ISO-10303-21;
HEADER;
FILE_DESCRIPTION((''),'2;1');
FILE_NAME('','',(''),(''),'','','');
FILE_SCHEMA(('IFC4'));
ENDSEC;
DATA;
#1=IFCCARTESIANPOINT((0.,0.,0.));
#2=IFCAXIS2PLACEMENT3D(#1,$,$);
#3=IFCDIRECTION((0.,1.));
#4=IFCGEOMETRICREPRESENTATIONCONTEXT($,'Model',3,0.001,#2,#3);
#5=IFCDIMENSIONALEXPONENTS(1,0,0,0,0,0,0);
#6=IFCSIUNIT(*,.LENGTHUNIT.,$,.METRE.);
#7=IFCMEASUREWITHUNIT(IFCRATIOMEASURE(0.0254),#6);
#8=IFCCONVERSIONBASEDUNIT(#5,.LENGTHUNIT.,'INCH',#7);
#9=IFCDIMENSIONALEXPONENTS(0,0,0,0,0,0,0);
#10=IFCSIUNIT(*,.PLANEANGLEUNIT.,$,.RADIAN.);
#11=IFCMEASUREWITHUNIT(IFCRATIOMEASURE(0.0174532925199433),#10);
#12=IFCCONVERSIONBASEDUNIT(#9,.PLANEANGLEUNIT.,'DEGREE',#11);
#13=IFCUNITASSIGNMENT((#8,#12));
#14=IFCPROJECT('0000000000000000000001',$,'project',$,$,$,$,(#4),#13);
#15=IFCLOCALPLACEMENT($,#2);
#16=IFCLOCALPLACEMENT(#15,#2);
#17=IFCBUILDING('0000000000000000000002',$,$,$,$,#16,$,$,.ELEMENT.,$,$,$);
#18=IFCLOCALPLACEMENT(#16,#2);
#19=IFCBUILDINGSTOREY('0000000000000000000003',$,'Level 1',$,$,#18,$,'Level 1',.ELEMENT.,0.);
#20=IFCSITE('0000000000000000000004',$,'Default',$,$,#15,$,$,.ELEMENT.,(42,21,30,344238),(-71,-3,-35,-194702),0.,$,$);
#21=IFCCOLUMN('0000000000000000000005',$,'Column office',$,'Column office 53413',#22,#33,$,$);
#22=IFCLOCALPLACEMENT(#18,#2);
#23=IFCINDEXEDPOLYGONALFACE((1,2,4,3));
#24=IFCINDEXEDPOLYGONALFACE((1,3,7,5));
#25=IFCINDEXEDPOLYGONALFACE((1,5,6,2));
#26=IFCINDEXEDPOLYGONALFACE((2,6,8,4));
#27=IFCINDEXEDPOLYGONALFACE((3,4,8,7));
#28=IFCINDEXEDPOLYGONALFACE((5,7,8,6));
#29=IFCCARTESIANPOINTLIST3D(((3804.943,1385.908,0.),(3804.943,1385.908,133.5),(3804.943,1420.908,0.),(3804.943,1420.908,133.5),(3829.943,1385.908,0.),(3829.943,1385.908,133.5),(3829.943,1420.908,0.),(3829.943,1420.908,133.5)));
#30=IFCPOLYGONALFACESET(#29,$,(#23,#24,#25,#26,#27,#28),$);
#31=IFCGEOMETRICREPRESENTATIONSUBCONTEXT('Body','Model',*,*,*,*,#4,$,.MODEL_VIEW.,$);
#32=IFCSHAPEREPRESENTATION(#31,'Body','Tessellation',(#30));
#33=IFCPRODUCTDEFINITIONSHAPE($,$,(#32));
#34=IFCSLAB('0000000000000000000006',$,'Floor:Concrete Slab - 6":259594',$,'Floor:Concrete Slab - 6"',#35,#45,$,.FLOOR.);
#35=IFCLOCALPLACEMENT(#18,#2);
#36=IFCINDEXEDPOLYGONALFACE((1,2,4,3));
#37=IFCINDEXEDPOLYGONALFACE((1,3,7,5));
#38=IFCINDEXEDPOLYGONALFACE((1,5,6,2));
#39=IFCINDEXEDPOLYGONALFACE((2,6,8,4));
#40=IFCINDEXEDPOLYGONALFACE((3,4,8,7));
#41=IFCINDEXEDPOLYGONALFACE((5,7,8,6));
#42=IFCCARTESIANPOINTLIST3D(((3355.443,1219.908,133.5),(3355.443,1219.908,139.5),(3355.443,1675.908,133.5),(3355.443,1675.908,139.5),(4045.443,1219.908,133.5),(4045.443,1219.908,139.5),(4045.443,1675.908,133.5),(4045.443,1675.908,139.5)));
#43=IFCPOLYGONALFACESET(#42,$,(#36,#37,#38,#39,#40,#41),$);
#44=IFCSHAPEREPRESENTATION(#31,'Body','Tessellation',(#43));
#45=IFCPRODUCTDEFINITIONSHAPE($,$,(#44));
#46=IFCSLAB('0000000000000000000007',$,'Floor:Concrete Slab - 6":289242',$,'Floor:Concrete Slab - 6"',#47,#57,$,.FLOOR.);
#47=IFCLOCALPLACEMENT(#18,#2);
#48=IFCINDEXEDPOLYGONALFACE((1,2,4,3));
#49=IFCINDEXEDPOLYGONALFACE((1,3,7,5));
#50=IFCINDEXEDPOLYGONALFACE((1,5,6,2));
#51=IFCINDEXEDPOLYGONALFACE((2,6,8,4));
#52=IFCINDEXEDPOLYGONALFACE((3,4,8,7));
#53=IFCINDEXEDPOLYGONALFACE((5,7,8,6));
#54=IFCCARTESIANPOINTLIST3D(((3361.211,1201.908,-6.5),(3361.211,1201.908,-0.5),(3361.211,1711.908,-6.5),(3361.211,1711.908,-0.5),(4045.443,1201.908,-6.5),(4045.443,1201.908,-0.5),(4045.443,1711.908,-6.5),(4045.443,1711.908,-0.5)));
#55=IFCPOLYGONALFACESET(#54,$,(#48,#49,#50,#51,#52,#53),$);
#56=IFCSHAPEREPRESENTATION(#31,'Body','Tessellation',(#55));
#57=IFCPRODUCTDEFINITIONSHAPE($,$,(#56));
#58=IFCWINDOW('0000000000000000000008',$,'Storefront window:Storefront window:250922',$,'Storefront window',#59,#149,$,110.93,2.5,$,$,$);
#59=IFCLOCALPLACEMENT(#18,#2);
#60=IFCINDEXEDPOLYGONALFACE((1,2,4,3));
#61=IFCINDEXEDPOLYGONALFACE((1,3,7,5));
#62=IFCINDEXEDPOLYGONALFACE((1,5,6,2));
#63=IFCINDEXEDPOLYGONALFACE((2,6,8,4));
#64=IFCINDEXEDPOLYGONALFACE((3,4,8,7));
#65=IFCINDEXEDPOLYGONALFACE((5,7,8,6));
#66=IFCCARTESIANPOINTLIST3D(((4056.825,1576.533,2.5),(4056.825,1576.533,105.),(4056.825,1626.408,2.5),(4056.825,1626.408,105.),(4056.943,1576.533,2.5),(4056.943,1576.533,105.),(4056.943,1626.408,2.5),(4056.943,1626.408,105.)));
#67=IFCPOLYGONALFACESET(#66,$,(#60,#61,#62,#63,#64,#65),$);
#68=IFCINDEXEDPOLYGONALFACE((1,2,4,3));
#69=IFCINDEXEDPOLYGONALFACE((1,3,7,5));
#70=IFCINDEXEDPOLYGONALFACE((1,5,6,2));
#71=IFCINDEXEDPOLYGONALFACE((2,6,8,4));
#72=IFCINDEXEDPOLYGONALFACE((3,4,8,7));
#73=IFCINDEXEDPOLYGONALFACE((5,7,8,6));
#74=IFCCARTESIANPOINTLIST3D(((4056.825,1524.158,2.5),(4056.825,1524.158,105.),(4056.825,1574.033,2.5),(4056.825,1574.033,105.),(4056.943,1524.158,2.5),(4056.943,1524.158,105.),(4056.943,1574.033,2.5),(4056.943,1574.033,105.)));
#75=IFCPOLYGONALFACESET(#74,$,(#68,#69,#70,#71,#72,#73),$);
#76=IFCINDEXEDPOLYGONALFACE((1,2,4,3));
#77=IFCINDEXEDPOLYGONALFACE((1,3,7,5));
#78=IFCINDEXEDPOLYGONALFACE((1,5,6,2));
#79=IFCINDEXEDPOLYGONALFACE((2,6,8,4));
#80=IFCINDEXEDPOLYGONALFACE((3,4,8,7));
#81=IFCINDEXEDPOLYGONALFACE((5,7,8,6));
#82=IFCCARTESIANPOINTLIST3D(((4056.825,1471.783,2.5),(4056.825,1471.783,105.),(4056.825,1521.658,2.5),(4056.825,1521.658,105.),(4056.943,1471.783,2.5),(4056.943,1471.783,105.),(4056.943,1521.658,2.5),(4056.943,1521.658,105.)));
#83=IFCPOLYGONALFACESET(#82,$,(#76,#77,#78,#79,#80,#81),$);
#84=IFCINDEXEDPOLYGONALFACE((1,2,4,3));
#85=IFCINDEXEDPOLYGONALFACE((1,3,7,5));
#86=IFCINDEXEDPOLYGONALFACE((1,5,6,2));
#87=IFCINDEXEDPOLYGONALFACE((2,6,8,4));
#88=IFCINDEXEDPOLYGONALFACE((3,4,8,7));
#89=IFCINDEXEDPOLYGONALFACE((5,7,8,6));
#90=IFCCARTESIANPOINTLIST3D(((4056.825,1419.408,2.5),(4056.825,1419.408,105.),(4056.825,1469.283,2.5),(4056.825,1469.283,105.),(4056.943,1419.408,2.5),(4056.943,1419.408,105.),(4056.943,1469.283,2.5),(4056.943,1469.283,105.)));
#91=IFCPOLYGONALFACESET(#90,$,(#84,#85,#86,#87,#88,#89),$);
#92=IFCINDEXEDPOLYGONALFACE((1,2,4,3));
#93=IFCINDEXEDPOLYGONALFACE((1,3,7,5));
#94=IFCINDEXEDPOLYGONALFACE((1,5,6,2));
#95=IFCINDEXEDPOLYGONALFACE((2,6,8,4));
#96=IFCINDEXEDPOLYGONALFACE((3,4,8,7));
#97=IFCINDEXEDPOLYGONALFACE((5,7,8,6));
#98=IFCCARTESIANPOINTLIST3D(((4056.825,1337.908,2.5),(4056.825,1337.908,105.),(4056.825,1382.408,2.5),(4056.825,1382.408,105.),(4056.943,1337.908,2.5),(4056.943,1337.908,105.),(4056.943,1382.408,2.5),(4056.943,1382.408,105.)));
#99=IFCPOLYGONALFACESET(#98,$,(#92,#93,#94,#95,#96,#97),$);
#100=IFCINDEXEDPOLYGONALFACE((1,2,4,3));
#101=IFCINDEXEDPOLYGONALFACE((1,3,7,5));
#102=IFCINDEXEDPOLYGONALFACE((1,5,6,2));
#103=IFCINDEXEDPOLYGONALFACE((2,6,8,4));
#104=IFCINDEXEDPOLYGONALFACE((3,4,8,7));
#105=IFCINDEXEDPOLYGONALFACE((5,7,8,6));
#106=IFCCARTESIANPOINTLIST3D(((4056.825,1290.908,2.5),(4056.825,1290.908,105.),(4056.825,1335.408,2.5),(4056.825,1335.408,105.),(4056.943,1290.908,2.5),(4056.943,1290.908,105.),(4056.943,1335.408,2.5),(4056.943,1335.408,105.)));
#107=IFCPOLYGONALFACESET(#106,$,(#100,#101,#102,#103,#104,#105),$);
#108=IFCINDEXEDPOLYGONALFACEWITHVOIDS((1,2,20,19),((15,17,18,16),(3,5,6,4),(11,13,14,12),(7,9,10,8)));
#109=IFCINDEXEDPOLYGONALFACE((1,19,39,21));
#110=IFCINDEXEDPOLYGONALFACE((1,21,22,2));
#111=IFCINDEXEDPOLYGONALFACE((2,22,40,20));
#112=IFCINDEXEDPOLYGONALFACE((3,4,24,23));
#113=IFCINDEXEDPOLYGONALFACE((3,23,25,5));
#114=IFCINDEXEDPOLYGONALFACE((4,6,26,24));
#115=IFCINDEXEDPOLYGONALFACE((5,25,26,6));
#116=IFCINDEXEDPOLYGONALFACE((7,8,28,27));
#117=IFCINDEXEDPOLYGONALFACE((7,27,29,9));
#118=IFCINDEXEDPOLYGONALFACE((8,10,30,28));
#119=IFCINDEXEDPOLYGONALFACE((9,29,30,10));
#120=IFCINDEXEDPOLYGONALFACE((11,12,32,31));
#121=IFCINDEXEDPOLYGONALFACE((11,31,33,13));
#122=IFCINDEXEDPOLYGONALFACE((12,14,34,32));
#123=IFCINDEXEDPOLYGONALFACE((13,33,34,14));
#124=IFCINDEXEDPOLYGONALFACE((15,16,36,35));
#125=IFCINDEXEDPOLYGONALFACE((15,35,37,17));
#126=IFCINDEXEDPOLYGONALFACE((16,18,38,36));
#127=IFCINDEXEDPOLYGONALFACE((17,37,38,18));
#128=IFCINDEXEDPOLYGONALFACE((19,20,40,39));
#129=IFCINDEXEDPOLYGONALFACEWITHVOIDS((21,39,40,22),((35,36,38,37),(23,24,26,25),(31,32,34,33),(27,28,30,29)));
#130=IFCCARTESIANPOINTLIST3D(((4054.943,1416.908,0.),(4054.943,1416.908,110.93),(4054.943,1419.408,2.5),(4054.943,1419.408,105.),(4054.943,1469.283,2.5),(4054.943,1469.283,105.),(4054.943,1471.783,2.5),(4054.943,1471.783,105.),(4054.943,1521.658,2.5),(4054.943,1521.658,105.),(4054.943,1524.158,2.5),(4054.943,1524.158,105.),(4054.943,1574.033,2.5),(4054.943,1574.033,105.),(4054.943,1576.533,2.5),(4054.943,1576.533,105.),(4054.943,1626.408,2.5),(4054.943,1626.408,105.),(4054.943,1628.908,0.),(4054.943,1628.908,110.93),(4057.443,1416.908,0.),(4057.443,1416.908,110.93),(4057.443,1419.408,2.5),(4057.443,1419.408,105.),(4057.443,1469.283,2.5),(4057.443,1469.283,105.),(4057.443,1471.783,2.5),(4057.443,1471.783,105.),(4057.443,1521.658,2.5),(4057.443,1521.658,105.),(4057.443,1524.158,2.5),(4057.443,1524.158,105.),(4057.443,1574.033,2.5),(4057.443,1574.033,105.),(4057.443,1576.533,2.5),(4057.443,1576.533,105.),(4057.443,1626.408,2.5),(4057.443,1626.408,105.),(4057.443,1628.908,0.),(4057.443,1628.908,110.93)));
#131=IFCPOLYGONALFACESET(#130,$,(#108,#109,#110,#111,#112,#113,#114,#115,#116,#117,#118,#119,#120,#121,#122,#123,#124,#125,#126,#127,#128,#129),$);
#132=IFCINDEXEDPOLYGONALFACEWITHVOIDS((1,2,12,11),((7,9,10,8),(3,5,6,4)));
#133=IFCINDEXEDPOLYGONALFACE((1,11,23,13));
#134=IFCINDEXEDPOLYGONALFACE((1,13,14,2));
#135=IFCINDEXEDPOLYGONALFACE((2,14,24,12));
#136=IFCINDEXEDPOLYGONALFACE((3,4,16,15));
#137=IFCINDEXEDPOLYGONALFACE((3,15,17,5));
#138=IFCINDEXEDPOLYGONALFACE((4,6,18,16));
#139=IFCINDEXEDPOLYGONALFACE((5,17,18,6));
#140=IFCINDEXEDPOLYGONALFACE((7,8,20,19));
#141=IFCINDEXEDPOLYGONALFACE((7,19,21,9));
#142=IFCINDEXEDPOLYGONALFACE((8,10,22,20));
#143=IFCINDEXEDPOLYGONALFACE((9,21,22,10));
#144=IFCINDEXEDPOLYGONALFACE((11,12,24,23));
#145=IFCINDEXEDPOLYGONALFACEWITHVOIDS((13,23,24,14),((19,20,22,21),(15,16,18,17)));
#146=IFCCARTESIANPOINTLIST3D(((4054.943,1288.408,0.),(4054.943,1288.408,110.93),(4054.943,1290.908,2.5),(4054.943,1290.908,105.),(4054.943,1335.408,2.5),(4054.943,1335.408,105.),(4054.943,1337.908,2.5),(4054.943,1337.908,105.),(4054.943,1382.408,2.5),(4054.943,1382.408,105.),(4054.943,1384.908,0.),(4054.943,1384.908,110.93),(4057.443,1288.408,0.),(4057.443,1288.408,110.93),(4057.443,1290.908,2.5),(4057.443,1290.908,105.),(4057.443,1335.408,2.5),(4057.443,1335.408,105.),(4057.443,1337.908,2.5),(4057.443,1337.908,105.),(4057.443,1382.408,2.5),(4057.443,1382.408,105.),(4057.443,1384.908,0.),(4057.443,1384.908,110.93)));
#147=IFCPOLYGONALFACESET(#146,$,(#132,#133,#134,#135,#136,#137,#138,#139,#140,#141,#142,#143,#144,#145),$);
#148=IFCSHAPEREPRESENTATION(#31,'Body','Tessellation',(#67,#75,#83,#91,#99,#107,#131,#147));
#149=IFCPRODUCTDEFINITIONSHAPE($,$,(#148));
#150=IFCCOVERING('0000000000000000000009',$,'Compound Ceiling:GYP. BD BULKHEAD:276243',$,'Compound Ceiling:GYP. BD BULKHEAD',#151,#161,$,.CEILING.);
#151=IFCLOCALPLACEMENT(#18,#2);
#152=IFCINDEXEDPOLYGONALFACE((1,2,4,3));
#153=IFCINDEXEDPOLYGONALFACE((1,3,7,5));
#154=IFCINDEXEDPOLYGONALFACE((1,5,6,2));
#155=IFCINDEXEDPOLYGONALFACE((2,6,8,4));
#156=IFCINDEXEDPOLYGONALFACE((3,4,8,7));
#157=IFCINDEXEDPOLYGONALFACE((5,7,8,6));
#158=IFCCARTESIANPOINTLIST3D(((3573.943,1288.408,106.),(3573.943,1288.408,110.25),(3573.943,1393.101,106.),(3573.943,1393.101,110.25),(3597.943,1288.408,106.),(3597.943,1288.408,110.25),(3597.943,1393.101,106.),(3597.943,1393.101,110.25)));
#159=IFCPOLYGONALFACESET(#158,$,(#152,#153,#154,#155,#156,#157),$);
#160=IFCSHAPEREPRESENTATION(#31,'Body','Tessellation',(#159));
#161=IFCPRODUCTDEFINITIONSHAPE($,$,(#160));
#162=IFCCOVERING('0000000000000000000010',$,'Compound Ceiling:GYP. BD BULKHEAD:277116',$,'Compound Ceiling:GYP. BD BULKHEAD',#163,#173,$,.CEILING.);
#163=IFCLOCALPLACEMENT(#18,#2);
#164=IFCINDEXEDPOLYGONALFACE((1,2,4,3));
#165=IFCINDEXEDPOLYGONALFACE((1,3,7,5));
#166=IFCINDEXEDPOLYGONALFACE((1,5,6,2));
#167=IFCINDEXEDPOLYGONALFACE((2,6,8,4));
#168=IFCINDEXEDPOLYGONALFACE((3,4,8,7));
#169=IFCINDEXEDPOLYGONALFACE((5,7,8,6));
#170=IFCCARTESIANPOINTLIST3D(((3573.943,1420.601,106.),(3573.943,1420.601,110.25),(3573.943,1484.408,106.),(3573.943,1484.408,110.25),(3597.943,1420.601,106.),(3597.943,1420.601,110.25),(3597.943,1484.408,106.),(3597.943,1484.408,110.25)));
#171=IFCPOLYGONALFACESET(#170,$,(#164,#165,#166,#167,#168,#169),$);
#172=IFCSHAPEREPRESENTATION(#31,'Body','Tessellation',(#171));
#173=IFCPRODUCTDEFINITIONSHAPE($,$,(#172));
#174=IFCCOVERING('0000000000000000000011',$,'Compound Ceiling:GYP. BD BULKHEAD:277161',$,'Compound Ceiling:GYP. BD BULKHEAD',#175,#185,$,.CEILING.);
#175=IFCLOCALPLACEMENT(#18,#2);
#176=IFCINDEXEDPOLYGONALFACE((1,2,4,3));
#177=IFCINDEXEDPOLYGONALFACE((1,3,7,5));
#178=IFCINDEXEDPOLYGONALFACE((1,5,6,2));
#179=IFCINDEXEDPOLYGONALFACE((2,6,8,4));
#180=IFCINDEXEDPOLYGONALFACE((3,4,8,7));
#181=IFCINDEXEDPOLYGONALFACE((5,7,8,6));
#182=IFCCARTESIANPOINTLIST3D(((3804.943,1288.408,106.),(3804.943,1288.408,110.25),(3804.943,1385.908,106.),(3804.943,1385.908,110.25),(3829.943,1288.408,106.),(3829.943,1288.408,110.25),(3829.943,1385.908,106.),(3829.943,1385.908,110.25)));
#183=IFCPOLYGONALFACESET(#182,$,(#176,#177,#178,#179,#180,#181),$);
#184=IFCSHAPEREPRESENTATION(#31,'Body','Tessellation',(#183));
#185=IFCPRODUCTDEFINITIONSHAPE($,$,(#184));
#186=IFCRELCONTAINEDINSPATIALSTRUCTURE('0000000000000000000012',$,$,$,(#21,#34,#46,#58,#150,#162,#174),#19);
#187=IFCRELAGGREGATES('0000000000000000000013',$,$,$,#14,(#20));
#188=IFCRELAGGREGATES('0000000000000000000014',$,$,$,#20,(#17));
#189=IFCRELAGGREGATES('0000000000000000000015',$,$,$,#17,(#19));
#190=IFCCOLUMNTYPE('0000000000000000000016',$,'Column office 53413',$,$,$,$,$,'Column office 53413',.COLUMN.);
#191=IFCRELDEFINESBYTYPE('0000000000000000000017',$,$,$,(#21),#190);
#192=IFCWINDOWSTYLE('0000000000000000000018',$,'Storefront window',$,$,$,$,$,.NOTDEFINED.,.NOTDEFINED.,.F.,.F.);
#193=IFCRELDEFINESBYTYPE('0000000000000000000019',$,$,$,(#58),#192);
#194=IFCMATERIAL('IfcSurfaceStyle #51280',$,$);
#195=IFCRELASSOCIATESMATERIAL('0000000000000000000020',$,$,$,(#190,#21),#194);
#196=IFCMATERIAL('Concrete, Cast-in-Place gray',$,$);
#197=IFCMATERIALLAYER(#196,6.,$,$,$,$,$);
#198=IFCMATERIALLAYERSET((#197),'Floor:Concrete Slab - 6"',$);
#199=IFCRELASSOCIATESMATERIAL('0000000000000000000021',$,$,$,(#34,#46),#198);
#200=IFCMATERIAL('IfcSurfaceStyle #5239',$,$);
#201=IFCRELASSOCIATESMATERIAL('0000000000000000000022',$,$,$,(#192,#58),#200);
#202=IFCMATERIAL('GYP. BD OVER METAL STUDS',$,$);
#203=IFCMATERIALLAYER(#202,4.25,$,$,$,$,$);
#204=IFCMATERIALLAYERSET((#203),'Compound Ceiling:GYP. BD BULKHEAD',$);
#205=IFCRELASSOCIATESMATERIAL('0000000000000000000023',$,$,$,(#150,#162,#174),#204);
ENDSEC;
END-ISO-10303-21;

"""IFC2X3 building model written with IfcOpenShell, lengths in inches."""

from ifc_helpers import new_model, entity, si_unit, converted_unit, direction, frame, frame_2d, origin, origin_2d_with_axis, place, context, subcontext, project, spatial, polyline, rectangle, outline, extrude, source, transform, mapped, material, layer, layer_set, layer_usage, type_object, type_shapes, element, save


model = new_model("IFC2X3")

# Units and contexts
model_context = context("Model", 3, precision=0.001, world=origin(), true_north=direction((0.0, 1.0)))
body_context = subcontext(model_context, "Body", "Model", "MODEL_VIEW")
ifc_project = project(units=[converted_unit("LENGTHUNIT", "INCH", entity("IfcRatioMeasure", 0.0254), si_unit("LENGTHUNIT", "METRE"), dimensions=[1, 0, 0, 0, 0, 0, 0]), converted_unit("PLANEANGLEUNIT", "DEGREE", entity("IfcRatioMeasure", 0.0174532925199433), si_unit("PLANEANGLEUNIT", "RADIAN"), dimensions=[0, 0, 0, 0, 0, 0, 0])], contexts=[model_context])

# Site, building, storey
site_placement = place(None, origin())
site = spatial("IfcSite", under=ifc_project, at=site_placement, Name="Default", CompositionType="ELEMENT", RefLatitude=(42, 21, 30, 344238), RefLongitude=(-71, -3, -35, -194702), RefElevation=0.0)
building_placement = place(site_placement, origin())
building = spatial("IfcBuilding", under=site, at=building_placement, CompositionType="ELEMENT")
storey_placement = place(building_placement, origin())
storey = spatial("IfcBuildingStorey", under=building, at=storey_placement, Name="Level 1", LongName="Level 1", CompositionType="ELEMENT", Elevation=0.0)

# Column
ifc_material_1 = material(Name="IfcSurfaceStyle #51280")
column_type = type_object("IfcColumnType", Name="Column office 53413", ElementType="Column office 53413", PredefinedType="COLUMN", material=ifc_material_1)
shared_shape_1 = source(origin(), body_context, "Body", "SweptSolid", [
    extrude(rectangle(XDim=35.0, YDim=25.0, at=frame_2d((0.0, 0.0), x_axis=(1.0, 0.0))), frame((3817.443, 1403.408, 0.0), z_axis=(0.0, 0.0, 1.0), x_axis=(0.0, -1.0, 0.0)), (0.0, 0.0, 1.0), 133.5),
])
type_shapes(column_type, [shared_shape_1])
column_placement = place(building_placement, origin())
element("IfcColumn", 1, at=column_placement, inside=storey, type_object=column_type, material=ifc_material_1, Name="Column office", ObjectType="Column office 53413", context=body_context, shape_type="MappedRepresentation", body=[
    mapped(shared_shape_1, transform((0.0, 0.0, 0.0), scale=1.0)),
])

# Slabs
ifc_material_2 = material(Name="Concrete, Cast-in-Place gray")
ifc_layer_1 = layer(ifc_material_2, 6.0)
ifc_layer_set_1 = layer_set([ifc_layer_1], Name="Floor:Concrete Slab - 6\"")
ifc_layer_usage_1 = layer_usage(ifc_layer_set_1, "AXIS3", "POSITIVE", 0.0)
slab_1_placement = place(building_placement, origin())
element("IfcSlab", 2, at=slab_1_placement, inside=storey, material=ifc_layer_usage_1, Name="Floor:Concrete Slab - 6\":259594", ObjectType="Floor:Concrete Slab - 6\"", PredefinedType="FLOOR", context=body_context, shape_type="SweptSolid", body=[
    extrude(rectangle(XDim=456.0, YDim=690.0, at=frame_2d((0.0, 0.0), x_axis=(1.0, 0.0))), frame((3700.443, 1447.908, 139.5), z_axis=(0.0, 0.0, -1.0), x_axis=(0.0, 1.0, 0.0)), (0.0, 0.0, 1.0), 6.0),
])
ifc_layer_usage_2 = layer_usage(ifc_layer_set_1, "AXIS3", "POSITIVE", 0.0)
slab_2_placement = place(building_placement, origin())
element("IfcSlab", 3, at=slab_2_placement, inside=storey, material=ifc_layer_usage_2, Name="Floor:Concrete Slab - 6\":289242", ObjectType="Floor:Concrete Slab - 6\"", PredefinedType="FLOOR", context=body_context, shape_type="SweptSolid", body=[
    extrude(rectangle(XDim=510.0, YDim=684.232, at=origin_2d_with_axis()), frame((3703.327, 1456.908, -0.5), z_axis=(0.0, 0.0, -1.0), x_axis=(0.0, 1.0, 0.0)), (0.0, 0.0, 1.0), 6.0),
])

# Window
ifc_material_3 = material(Name="IfcSurfaceStyle #5239")
window_style = type_object("IfcWindowStyle", Name="Storefront window", ConstructionType="NOTDEFINED", OperationType="NOTDEFINED", ParameterTakesPrecedence=False, Sizeable=False, material=ifc_material_3)
shared_shape_2 = source(origin(), body_context, "Body", "SweptSolid", [
    extrude(rectangle(XDim=0.118, YDim=49.875, at=frame_2d((0.0, 0.0), x_axis=(1.0, 0.0))), frame((4056.884, 1601.47, 2.5), z_axis=(0.0, 0.0, 1.0), x_axis=(-1.0, 0.0, 0.0)), (0.0, 0.0, 1.0), 102.5),
    extrude(rectangle(XDim=0.118, YDim=49.875, at=frame_2d((0.0, 0.0), x_axis=(1.0, 0.0))), frame((4056.884, 1549.095, 2.5), z_axis=(0.0, 0.0, 1.0), x_axis=(-1.0, 0.0, 0.0)), (0.0, 0.0, 1.0), 102.5),
    extrude(rectangle(XDim=0.118, YDim=49.875, at=frame_2d((0.0, 0.0), x_axis=(1.0, 0.0))), frame((4056.884, 1496.72, 2.5), z_axis=(0.0, 0.0, 1.0), x_axis=(-1.0, 0.0, 0.0)), (0.0, 0.0, 1.0), 102.5),
    extrude(rectangle(XDim=0.118, YDim=49.875, at=frame_2d((0.0, 0.0), x_axis=(1.0, 0.0))), frame((4056.884, 1444.345, 2.5), z_axis=(0.0, 0.0, 1.0), x_axis=(-1.0, 0.0, 0.0)), (0.0, 0.0, 1.0), 102.5),
    extrude(rectangle(XDim=0.118, YDim=44.5, at=frame_2d((0.0, 0.0), x_axis=(1.0, 0.0))), frame((4056.884, 1360.158, 2.5), z_axis=(0.0, 0.0, 1.0), x_axis=(-1.0, 0.0, 0.0)), (0.0, 0.0, 1.0), 102.5),
    extrude(rectangle(XDim=0.118, YDim=44.5, at=frame_2d((0.0, 0.0), x_axis=(1.0, 0.0))), frame((4056.884, 1313.158, 2.5), z_axis=(0.0, 0.0, 1.0), x_axis=(-1.0, 0.0, 0.0)), (0.0, 0.0, 1.0), 102.5),
    extrude(outline(polyline([(-55.465, -106.0), (55.465, -106.0), (55.465, 106.0), (-55.465, 106.0), (-55.465, -106.0)]), holes=[polyline([(-49.535, 53.625), (-49.535, 103.5), (52.965, 103.5), (52.965, 53.625), (-49.535, 53.625)]), polyline([(52.965, 1.25), (-49.535, 1.25), (-49.535, 51.125), (52.965, 51.125), (52.965, 1.25)]), polyline([(-49.535, -1.25), (52.965, -1.25), (52.965, -51.125), (-49.535, -51.125), (-49.535, -1.25)]), polyline([(-49.535, -103.5), (-49.535, -53.625), (52.965, -53.625), (52.965, -103.5), (-49.535, -103.5)])]), frame((4054.943, 1522.908, 55.465), z_axis=(1.0, 0.0, 0.0), x_axis=(0.0, 0.0, -1.0)), (0.0, 0.0, 1.0), 2.5),
    extrude(outline(polyline([(-55.465, -48.25), (55.465, -48.25), (55.465, 48.25), (-55.465, 48.25), (-55.465, -48.25)]), holes=[polyline([(-49.535, 1.25), (-49.535, 45.75), (52.965, 45.75), (52.965, 1.25), (-49.535, 1.25)]), polyline([(-49.535, -45.75), (-49.535, -1.25), (52.965, -1.25), (52.965, -45.75), (-49.535, -45.75)])]), frame((4054.943, 1336.658, 55.465), z_axis=(1.0, 0.0, 0.0), x_axis=(0.0, 0.0, -1.0)), (0.0, 0.0, 1.0), 2.5),
])
type_shapes(window_style, [shared_shape_2])
window_placement = place(building_placement, origin())
element("IfcWindow", 4, at=window_placement, inside=storey, type_object=window_style, material=ifc_material_3, Name="Storefront window:Storefront window:250922", ObjectType="Storefront window", OverallHeight=110.93, OverallWidth=2.5, context=body_context, shape_type="MappedRepresentation", body=[
    mapped(shared_shape_2, transform((0.0, 0.0, 0.0), scale=1.0)),
])

# Coverings
ifc_material_4 = material(Name="GYP. BD OVER METAL STUDS")
ifc_layer_2 = layer(ifc_material_4, 4.25)
ifc_layer_set_2 = layer_set([ifc_layer_2], Name="Compound Ceiling:GYP. BD BULKHEAD")
ifc_layer_usage_3 = layer_usage(ifc_layer_set_2, "AXIS3", "NEGATIVE", 0.0)
covering_1_placement = place(building_placement, origin())
element("IfcCovering", 5, at=covering_1_placement, inside=storey, material=ifc_layer_usage_3, Name="Compound Ceiling:GYP. BD BULKHEAD:276243", ObjectType="Compound Ceiling:GYP. BD BULKHEAD", PredefinedType="CEILING", context=body_context, shape_type="SweptSolid", body=[
    extrude(rectangle(XDim=24.0, YDim=104.693, at=frame_2d((0.0, 0.0), x_axis=(1.0, 0.0))), frame((3585.943, 1340.754, 106.0), z_axis=(0.0, 0.0, 1.0), x_axis=(-1.0, 0.0, 0.0)), (0.0, 0.0, 1.0), 4.25),
])
ifc_layer_usage_4 = layer_usage(ifc_layer_set_2, "AXIS3", "NEGATIVE", 0.0)
covering_2_placement = place(storey_placement, origin())
element("IfcCovering", 6, at=covering_2_placement, inside=storey, material=ifc_layer_usage_4, Name="Compound Ceiling:GYP. BD BULKHEAD:277116", ObjectType="Compound Ceiling:GYP. BD BULKHEAD", PredefinedType="CEILING", context=body_context, shape_type="SweptSolid", body=[
    extrude(rectangle(XDim=24.0, YDim=63.807, at=frame_2d((0.0, 0.0), x_axis=(1.0, 0.0))), frame((3585.943, 1452.504, 106.0), z_axis=(0.0, 0.0, 1.0), x_axis=(-1.0, 0.0, 0.0)), (0.0, 0.0, 1.0), 4.25),
])
ifc_layer_usage_5 = layer_usage(ifc_layer_set_2, "AXIS3", "NEGATIVE", 0.0)
covering_3_placement = place(storey_placement, origin())
element("IfcCovering", 7, at=covering_3_placement, inside=storey, material=ifc_layer_usage_5, Name="Compound Ceiling:GYP. BD BULKHEAD:277161", ObjectType="Compound Ceiling:GYP. BD BULKHEAD", PredefinedType="CEILING", context=body_context, shape_type="SweptSolid", body=[
    extrude(rectangle(XDim=25.0, YDim=97.5, at=frame_2d((0.0, 0.0), x_axis=(1.0, 0.0))), frame((3817.443, 1337.158, 106.0), z_axis=(0.0, 0.0, 1.0), x_axis=(-1.0, 0.0, 0.0)), (0.0, 0.0, 1.0), 4.25),
])

save(model, "model.ifc")
